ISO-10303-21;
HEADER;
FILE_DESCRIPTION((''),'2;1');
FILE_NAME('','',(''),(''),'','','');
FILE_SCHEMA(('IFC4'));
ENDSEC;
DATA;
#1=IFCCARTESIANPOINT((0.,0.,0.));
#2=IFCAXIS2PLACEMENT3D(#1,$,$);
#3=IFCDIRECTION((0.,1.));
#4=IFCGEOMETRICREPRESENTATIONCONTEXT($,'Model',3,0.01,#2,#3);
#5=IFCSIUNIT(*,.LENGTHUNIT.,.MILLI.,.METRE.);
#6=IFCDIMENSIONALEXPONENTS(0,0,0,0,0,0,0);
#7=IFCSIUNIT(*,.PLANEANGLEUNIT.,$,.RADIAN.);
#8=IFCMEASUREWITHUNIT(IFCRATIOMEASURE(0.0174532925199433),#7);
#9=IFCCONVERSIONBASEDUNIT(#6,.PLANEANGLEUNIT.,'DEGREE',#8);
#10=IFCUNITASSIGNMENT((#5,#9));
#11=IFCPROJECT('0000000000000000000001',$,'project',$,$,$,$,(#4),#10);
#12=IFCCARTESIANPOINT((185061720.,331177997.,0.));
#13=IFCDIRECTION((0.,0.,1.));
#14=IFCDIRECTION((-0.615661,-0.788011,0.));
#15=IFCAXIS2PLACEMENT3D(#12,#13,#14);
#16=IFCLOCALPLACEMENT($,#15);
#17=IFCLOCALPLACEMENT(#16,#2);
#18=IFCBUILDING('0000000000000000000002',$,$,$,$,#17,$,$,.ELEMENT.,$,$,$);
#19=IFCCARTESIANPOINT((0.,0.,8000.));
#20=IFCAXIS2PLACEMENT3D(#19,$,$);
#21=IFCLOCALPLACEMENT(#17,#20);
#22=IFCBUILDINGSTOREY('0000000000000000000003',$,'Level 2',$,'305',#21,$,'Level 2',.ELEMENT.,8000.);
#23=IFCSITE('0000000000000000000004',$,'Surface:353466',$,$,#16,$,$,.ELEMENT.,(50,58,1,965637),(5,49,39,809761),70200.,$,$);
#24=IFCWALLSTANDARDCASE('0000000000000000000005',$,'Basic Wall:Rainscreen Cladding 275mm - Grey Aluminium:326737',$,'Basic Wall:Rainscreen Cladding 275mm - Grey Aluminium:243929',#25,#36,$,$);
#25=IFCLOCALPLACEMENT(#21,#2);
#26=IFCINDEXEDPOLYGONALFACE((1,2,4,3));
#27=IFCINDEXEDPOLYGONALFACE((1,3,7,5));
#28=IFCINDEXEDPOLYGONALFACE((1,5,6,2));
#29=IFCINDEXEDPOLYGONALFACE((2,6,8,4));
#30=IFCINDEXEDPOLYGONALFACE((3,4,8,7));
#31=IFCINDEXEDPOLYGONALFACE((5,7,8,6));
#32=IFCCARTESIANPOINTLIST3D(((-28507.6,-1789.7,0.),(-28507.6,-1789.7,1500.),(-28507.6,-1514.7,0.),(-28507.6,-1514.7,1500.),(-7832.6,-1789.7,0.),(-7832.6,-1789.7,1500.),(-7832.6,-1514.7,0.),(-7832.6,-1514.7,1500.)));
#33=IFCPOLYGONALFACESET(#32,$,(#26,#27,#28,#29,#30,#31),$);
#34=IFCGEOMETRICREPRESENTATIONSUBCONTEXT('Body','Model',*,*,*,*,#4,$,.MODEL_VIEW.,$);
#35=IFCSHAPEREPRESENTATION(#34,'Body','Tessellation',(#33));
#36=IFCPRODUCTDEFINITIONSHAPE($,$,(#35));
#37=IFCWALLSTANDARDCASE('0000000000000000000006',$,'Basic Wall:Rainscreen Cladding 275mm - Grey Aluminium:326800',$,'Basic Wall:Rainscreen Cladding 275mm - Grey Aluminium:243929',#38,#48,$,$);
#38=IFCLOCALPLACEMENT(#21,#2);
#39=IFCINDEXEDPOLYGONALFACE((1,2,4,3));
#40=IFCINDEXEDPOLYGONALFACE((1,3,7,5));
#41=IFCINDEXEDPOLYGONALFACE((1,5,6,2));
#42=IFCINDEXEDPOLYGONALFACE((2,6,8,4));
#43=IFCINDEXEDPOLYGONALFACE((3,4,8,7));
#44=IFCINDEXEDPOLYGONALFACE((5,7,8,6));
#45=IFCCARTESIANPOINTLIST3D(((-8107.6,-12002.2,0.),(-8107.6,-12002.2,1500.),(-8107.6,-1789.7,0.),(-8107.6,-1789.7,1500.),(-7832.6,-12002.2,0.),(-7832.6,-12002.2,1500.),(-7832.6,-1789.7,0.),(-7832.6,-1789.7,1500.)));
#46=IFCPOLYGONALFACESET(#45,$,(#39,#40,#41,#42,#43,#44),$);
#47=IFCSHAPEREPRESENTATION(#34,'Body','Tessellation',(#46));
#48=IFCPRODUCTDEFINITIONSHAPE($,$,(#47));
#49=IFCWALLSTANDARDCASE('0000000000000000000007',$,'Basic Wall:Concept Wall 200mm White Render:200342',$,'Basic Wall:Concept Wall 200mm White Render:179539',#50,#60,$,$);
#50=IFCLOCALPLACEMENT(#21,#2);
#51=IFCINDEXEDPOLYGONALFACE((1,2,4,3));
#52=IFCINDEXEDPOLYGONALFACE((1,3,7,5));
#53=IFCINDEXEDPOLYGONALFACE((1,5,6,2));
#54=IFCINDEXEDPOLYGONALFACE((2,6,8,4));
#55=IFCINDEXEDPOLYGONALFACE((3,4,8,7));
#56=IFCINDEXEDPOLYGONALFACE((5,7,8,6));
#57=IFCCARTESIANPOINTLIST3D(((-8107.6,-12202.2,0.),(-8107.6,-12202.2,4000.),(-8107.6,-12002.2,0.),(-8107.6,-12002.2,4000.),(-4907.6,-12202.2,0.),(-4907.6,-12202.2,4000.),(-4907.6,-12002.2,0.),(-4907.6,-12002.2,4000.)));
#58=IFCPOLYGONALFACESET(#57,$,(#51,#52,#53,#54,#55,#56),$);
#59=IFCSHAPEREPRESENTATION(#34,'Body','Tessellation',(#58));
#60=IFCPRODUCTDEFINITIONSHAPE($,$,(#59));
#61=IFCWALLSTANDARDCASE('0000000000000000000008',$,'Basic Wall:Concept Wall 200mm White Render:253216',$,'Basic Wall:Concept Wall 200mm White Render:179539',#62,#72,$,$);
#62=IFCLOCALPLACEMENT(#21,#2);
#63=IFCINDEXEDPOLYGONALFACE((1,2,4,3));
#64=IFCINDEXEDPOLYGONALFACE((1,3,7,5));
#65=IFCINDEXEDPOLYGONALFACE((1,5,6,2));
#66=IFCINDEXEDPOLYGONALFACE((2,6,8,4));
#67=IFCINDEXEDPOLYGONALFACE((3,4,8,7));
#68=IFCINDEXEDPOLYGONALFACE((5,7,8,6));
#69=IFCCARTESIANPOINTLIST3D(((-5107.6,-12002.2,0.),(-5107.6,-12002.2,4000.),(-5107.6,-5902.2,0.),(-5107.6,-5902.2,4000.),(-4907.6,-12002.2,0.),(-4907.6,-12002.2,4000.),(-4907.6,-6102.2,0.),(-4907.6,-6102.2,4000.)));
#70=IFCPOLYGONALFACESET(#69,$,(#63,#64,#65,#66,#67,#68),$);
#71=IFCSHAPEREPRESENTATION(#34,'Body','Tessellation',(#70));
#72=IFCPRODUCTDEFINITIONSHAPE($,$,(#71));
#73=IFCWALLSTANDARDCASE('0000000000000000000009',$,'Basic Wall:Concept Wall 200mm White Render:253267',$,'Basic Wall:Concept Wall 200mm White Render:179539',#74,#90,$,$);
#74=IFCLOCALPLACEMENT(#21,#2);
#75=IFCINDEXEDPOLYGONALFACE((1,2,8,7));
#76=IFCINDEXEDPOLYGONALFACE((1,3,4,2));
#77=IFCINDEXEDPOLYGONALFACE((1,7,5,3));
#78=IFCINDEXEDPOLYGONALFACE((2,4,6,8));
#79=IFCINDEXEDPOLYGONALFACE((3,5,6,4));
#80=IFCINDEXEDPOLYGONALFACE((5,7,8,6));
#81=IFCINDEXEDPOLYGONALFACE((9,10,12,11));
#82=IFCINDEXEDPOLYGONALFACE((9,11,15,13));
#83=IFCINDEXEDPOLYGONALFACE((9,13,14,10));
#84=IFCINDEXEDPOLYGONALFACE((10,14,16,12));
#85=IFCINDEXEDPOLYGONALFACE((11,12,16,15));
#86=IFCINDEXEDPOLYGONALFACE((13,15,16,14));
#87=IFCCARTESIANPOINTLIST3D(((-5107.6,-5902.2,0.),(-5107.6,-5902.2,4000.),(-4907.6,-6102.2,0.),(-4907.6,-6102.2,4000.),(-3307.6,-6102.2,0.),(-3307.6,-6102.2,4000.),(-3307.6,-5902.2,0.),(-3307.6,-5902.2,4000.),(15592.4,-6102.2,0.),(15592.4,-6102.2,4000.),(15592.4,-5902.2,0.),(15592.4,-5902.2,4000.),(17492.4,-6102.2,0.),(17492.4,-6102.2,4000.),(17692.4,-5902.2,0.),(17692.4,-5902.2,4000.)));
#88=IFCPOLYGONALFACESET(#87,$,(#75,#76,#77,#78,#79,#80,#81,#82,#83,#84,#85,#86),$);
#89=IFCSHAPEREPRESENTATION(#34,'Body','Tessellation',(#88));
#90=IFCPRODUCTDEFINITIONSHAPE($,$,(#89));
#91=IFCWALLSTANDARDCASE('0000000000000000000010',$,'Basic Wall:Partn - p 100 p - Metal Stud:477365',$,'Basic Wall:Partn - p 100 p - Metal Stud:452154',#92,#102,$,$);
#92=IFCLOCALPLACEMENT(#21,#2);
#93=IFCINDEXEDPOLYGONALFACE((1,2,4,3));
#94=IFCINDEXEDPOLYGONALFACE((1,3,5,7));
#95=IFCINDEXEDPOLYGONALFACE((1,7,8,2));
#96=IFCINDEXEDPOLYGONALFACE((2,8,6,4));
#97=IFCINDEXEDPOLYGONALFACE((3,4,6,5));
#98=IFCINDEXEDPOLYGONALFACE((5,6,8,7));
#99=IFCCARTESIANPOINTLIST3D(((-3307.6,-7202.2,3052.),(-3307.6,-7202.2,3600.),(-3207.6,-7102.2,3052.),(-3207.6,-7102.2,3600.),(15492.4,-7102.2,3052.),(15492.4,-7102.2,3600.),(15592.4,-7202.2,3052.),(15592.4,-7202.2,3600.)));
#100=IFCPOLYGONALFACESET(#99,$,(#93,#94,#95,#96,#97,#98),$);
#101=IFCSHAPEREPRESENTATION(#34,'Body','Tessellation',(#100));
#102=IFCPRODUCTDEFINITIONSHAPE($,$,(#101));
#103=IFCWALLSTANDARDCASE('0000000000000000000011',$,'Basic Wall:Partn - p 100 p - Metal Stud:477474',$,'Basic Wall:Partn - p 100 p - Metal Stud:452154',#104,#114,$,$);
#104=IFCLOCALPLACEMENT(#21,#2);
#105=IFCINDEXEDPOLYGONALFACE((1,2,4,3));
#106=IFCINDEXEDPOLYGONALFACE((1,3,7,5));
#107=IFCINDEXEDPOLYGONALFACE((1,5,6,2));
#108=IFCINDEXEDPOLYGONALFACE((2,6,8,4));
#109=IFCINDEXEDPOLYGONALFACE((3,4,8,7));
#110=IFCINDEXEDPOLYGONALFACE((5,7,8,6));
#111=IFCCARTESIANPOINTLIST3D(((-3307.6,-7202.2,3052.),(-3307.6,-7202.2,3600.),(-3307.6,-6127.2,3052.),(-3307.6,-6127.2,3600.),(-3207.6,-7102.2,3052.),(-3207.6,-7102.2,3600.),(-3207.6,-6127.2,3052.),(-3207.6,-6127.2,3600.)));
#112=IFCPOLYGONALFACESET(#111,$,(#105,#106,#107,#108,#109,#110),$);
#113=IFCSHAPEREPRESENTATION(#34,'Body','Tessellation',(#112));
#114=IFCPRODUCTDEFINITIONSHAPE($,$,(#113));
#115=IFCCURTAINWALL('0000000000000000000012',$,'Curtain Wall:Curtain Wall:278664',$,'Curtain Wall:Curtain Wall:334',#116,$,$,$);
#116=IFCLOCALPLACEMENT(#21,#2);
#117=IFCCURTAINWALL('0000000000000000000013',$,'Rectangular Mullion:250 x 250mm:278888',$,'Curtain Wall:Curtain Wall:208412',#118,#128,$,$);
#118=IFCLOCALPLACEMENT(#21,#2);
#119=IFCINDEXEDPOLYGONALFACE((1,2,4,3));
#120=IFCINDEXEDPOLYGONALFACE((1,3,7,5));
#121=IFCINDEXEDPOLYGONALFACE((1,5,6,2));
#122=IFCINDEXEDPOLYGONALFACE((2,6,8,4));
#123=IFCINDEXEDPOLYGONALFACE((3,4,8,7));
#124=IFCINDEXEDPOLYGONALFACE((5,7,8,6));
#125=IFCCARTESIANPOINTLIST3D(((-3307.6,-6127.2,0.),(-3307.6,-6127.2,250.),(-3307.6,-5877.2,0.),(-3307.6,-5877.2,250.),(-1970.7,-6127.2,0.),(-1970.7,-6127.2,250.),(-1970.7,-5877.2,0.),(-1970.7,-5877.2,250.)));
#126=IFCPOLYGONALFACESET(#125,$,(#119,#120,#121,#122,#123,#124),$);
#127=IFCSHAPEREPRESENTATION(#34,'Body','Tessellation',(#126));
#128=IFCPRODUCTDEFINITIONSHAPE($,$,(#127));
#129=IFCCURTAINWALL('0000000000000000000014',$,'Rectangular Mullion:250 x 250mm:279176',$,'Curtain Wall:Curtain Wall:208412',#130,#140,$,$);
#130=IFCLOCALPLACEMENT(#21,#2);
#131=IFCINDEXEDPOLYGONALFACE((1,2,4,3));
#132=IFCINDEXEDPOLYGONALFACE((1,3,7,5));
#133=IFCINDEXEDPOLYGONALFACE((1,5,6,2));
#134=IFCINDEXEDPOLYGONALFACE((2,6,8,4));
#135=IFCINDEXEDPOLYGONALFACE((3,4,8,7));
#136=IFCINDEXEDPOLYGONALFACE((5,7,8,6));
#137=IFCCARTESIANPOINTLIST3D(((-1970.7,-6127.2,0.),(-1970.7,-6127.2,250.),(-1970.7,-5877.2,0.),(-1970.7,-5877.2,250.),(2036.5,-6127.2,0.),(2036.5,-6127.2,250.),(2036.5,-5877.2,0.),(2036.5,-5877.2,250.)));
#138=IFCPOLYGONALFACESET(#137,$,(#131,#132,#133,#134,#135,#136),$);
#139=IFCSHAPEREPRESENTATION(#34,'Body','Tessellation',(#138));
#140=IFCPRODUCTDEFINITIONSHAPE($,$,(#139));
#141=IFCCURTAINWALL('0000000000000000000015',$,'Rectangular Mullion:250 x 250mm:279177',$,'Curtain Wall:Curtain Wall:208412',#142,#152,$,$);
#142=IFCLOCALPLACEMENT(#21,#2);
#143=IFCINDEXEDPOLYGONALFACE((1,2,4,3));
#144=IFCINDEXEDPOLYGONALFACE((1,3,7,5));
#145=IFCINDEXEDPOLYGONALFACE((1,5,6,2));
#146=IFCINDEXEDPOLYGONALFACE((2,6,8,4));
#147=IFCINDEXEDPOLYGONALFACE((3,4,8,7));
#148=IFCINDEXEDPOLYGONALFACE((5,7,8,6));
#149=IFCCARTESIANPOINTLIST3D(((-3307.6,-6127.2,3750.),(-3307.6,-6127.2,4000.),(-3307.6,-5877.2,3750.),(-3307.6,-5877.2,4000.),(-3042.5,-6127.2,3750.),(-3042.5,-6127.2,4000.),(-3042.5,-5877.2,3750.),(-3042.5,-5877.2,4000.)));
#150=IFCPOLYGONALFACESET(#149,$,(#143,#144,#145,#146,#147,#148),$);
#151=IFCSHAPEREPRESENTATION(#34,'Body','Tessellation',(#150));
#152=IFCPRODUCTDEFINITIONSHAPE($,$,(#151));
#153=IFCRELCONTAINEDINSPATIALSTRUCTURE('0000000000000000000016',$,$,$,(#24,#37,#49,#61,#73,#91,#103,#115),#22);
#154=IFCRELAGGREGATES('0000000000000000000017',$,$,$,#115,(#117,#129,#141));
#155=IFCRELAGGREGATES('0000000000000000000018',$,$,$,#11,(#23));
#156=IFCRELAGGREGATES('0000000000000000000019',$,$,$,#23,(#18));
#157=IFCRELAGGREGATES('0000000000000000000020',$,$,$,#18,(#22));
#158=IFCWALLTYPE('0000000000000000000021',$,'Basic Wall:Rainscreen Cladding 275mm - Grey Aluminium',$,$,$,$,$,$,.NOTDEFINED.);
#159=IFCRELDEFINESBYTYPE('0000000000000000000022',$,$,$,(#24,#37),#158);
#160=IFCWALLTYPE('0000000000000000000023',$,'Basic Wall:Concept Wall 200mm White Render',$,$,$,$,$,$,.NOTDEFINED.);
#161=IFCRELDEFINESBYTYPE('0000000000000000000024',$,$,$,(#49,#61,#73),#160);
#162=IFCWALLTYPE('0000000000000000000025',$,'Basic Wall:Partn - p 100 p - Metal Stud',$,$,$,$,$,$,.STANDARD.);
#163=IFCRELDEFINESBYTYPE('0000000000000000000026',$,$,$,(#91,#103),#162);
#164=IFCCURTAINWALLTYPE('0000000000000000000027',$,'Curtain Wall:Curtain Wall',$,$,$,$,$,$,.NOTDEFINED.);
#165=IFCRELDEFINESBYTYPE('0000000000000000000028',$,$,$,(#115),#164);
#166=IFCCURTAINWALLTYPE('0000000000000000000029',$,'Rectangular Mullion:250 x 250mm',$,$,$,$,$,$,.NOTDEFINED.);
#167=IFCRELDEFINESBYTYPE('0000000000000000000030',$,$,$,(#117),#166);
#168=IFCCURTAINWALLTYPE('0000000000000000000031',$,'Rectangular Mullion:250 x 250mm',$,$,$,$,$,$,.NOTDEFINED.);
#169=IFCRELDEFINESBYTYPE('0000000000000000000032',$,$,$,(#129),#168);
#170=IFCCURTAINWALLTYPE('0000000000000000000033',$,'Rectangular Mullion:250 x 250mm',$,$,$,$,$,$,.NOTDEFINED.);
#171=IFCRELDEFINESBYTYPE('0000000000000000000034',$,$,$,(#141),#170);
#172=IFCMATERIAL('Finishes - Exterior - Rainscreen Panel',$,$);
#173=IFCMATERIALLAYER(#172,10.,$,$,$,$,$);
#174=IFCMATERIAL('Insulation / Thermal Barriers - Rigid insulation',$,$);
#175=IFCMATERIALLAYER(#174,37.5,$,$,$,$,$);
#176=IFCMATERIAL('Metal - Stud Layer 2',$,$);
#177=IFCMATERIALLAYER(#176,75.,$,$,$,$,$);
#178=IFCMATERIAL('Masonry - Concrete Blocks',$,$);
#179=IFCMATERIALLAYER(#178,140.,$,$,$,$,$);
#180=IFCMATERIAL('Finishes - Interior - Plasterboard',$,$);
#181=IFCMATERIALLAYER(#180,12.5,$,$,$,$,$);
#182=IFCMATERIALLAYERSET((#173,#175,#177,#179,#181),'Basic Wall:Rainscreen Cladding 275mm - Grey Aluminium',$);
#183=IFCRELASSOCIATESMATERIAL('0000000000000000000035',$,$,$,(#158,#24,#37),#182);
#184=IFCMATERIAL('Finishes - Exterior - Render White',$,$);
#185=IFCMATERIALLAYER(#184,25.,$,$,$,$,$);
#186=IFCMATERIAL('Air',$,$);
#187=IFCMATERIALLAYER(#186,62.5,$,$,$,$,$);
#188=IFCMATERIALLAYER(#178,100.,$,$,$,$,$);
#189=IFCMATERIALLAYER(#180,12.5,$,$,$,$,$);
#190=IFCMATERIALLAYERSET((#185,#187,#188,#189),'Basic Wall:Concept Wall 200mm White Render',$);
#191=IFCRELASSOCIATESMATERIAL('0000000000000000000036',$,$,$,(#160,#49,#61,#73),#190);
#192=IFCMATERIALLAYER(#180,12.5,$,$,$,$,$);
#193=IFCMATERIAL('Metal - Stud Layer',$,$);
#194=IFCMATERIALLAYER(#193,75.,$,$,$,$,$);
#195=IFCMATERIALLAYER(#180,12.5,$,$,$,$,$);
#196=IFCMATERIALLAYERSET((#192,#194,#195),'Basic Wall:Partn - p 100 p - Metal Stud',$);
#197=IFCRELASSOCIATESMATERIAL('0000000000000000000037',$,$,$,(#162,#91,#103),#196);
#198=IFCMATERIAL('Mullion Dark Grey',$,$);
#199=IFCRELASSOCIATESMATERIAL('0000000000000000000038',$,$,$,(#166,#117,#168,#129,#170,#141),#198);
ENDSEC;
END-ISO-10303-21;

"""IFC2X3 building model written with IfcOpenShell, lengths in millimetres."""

from ifc_helpers import new_model, entity, si_unit, converted_unit, direction, frame, frame_2d, origin, origin_2d_with_axis, place, context, subcontext, project, spatial, polyline, rectangle, outline, extrude, clip, halfspace, bounded_halfspace, source, transform, mapped, material, layer, layer_set, layer_usage, type_object, type_shapes, element, aggregate, save


model = new_model("IFC2X3")

# Units and contexts
model_context = context("Model", 3, precision=0.01, world=origin(), true_north=direction((0.0, 1.0)))
body_context = subcontext(model_context, "Body", "Model", "MODEL_VIEW")
ifc_project = project(units=[si_unit("LENGTHUNIT", "METRE", prefix="MILLI"), converted_unit("PLANEANGLEUNIT", "DEGREE", entity("IfcRatioMeasure", 0.0174532925199433), si_unit("PLANEANGLEUNIT", "RADIAN"), dimensions=[0, 0, 0, 0, 0, 0, 0])], contexts=[model_context])

# Site, building, storey
site_placement = place(None, frame((185061720.0, 331177997.0, 0.0), z_axis=(0.0, 0.0, 1.0), x_axis=(-0.615661, -0.788011, 0.0)))
site = spatial("IfcSite", under=ifc_project, at=site_placement, Name="Surface:353466", CompositionType="ELEMENT", RefLatitude=(50, 58, 1, 965637), RefLongitude=(5, 49, 39, 809761), RefElevation=70200.0)
building_placement = place(site_placement, origin())
building = spatial("IfcBuilding", under=site, at=building_placement, CompositionType="ELEMENT")
storey_placement = place(building_placement, frame((0.0, 0.0, 8000.0)))
storey = spatial("IfcBuildingStorey", under=building, at=storey_placement, Name="Level 2", ObjectType="305", LongName="Level 2", CompositionType="ELEMENT", Elevation=8000.0)

# Walls
ifc_material_1 = material(Name="Finishes - Exterior - Rainscreen Panel")
ifc_layer_1 = layer(ifc_material_1, 10.0)
ifc_material_2 = material(Name="Insulation / Thermal Barriers - Rigid insulation")
ifc_layer_2 = layer(ifc_material_2, 37.5)
ifc_material_3 = material(Name="Metal - Stud Layer 2")
ifc_layer_3 = layer(ifc_material_3, 75.0)
ifc_material_4 = material(Name="Masonry - Concrete Blocks")
ifc_layer_4 = layer(ifc_material_4, 140.0)
ifc_material_5 = material(Name="Finishes - Interior - Plasterboard")
ifc_layer_5 = layer(ifc_material_5, 12.5)
ifc_layer_set_1 = layer_set([ifc_layer_1, ifc_layer_2, ifc_layer_3, ifc_layer_4, ifc_layer_5], Name="Basic Wall:Rainscreen Cladding 275mm - Grey Aluminium")
ifc_layer_usage_1 = layer_usage(ifc_layer_set_1, "AXIS2", "NEGATIVE", 137.5)
wall_type_1 = type_object("IfcWallType", Name="Basic Wall:Rainscreen Cladding 275mm - Grey Aluminium", PredefinedType="NOTDEFINED", material=ifc_layer_set_1)
wall_1_placement = place(storey_placement, frame((-28507.6, -1652.2, 0.0)))
element("IfcWallStandardCase", 1, at=wall_1_placement, inside=storey, type_object=wall_type_1, material=ifc_layer_usage_1, Name="Basic Wall:Rainscreen Cladding 275mm - Grey Aluminium:326737", ObjectType="Basic Wall:Rainscreen Cladding 275mm - Grey Aluminium:243929", context=body_context, shape_type="Clipping", body=[
    clip(extrude(rectangle(XDim=20675.0, YDim=275.0, at=frame_2d((10337.5, 0.0), x_axis=(-1.0, 0.0))), origin(), (0.0, 0.0, 1.0), 1500.0), halfspace(frame((0.0, 0.0, -8000.0)), True)),
])
ifc_layer_usage_2 = layer_usage(ifc_layer_set_1, "AXIS2", "NEGATIVE", 137.5)
wall_2_placement = place(storey_placement, frame((-7970.1, -1789.7, 0.0), z_axis=(0.0, 0.0, 1.0), x_axis=(0.0, -1.0, 0.0)))
element("IfcWallStandardCase", 2, at=wall_2_placement, inside=storey, type_object=wall_type_1, material=ifc_layer_usage_2, Name="Basic Wall:Rainscreen Cladding 275mm - Grey Aluminium:326800", ObjectType="Basic Wall:Rainscreen Cladding 275mm - Grey Aluminium:243929", context=body_context, shape_type="Clipping", body=[
    clip(extrude(rectangle(XDim=10212.5, YDim=275.0, at=frame_2d((5106.2, 0.0), x_axis=(-1.0, 0.0))), origin(), (0.0, 0.0, 1.0), 1500.0), halfspace(frame((0.0, 0.0, -8000.0)), True)),
])
ifc_material_6 = material(Name="Finishes - Exterior - Render White")
ifc_layer_6 = layer(ifc_material_6, 25.0)
ifc_material_7 = material(Name="Air")
ifc_layer_7 = layer(ifc_material_7, 62.5)
ifc_layer_8 = layer(ifc_material_4, 100.0)
ifc_layer_9 = layer(ifc_material_5, 12.5)
ifc_layer_set_2 = layer_set([ifc_layer_6, ifc_layer_7, ifc_layer_8, ifc_layer_9], Name="Basic Wall:Concept Wall 200mm White Render")
ifc_layer_usage_3 = layer_usage(ifc_layer_set_2, "AXIS2", "NEGATIVE", 100.0)
wall_type_2 = type_object("IfcWallType", Name="Basic Wall:Concept Wall 200mm White Render", PredefinedType="NOTDEFINED", material=ifc_layer_set_2)
wall_3_placement = place(storey_placement, frame((-8107.6, -12102.2, 0.0)))
element("IfcWallStandardCase", 3, at=wall_3_placement, inside=storey, type_object=wall_type_2, material=ifc_layer_usage_3, Name="Basic Wall:Concept Wall 200mm White Render:200342", ObjectType="Basic Wall:Concept Wall 200mm White Render:179539", context=body_context, shape_type="Clipping", body=[
    clip(extrude(rectangle(XDim=3200.0, YDim=200.0, at=frame_2d((1600.0, 0.0), x_axis=(-1.0, 0.0))), origin(), (0.0, 0.0, 1.0), 4000.0), halfspace(frame((0.0, 0.0, -8000.0)), True)),
])
ifc_layer_usage_4 = layer_usage(ifc_layer_set_2, "AXIS2", "NEGATIVE", 100.0)
wall_4_placement = place(storey_placement, frame((-5007.6, -12002.2, 0.0), z_axis=(0.0, 0.0, 1.0), x_axis=(0.0, 1.0, 0.0)))
element("IfcWallStandardCase", 4, at=wall_4_placement, inside=storey, type_object=wall_type_2, material=ifc_layer_usage_4, Name="Basic Wall:Concept Wall 200mm White Render:253216", ObjectType="Basic Wall:Concept Wall 200mm White Render:179539", context=body_context, shape_type="Clipping", body=[
    clip(extrude(outline(polyline([(5900.0, -100.0), (6100.0, 100.0), (0.0, 100.0), (0.0, -100.0), (5900.0, -100.0)])), origin(), (0.0, 0.0, 1.0), 4000.0), halfspace(frame((0.0, 0.0, -8000.0)), True)),
])

# Wall, opening
ifc_layer_usage_5 = layer_usage(ifc_layer_set_2, "AXIS2", "NEGATIVE", 100.0)
wall_5_placement = place(storey_placement, frame((-5107.6, -6002.2, 0.0)))
wall_5 = element("IfcWallStandardCase", 5, at=wall_5_placement, inside=storey, type_object=wall_type_2, material=ifc_layer_usage_5, Name="Basic Wall:Concept Wall 200mm White Render:253267", ObjectType="Basic Wall:Concept Wall 200mm White Render:179539", context=body_context, shape_type="Clipping", body=[
    clip(extrude(outline(polyline([(200.0, -100.0), (22600.0, -100.0), (22800.0, 100.0), (0.0, 100.0), (200.0, -100.0)])), origin(), (0.0, 0.0, 1.0), 4000.0), halfspace(frame((0.0, 0.0, -8000.0)), True)),
])
opening_1_placement = place(wall_5_placement, frame((1800.0, -252.4, 0.0)))
element("IfcOpeningElement", 6, at=opening_1_placement, cuts=wall_5, ObjectType="Opening", context=body_context, shape_type="SweptSolid", body=[
    extrude(rectangle(XDim=4000.0, YDim=18900.0, at=frame_2d((0.0, 0.0), x_axis=(1.0, 0.0))), frame((9450.0, 0.0, 2000.0), z_axis=(0.0, 1.0, 0.0), x_axis=(0.0, 0.0, 1.0)), (0.0, 0.0, 1.0), 504.8),
])

# Walls
ifc_layer_10 = layer(ifc_material_5, 12.5)
ifc_material_8 = material(Name="Metal - Stud Layer")
ifc_layer_11 = layer(ifc_material_8, 75.0)
ifc_layer_12 = layer(ifc_material_5, 12.5)
ifc_layer_set_3 = layer_set([ifc_layer_10, ifc_layer_11, ifc_layer_12], Name="Basic Wall:Partn - p 100 p - Metal Stud")
ifc_layer_usage_6 = layer_usage(ifc_layer_set_3, "AXIS2", "NEGATIVE", 50.0)
wall_type_3 = type_object("IfcWallType", Name="Basic Wall:Partn - p 100 p - Metal Stud", PredefinedType="STANDARD", material=ifc_layer_set_3)
wall_6_placement = place(storey_placement, frame((-3307.6, -7152.2, 3052.0)))
element("IfcWallStandardCase", 7, at=wall_6_placement, inside=storey, type_object=wall_type_3, material=ifc_layer_usage_6, Name="Basic Wall:Partn - p 100 p - Metal Stud:477365", ObjectType="Basic Wall:Partn - p 100 p - Metal Stud:452154", context=body_context, shape_type="Clipping", body=[
    clip(extrude(outline(polyline([(18900.0, -50.0), (18800.0, 50.0), (100.0, 50.0), (0.0, -50.0), (18900.0, -50.0)])), origin(), (0.0, 0.0, 1.0), 548.0), bounded_halfspace(frame((0.0, -50.0, 548.0), z_axis=(0.0, 0.0, -1.0), x_axis=(1.0, 0.0, 0.0)), True, frame((0.0, -50.0, 548.0)), polyline([(0.0, 0.0), (18900.0, 0.0), (18800.0, 100.0), (100.0, 100.0), (0.0, 0.0)]))),
])
ifc_layer_usage_7 = layer_usage(ifc_layer_set_3, "AXIS2", "NEGATIVE", 50.0)
wall_7_placement = place(storey_placement, frame((-3257.6, -6127.2, 3052.0), z_axis=(0.0, 0.0, 1.0), x_axis=(0.0, -1.0, 0.0)))
element("IfcWallStandardCase", 8, at=wall_7_placement, inside=storey, type_object=wall_type_3, material=ifc_layer_usage_7, Name="Basic Wall:Partn - p 100 p - Metal Stud:477474", ObjectType="Basic Wall:Partn - p 100 p - Metal Stud:452154", context=body_context, shape_type="SweptSolid", body=[
    extrude(outline(polyline([(1075.0, -50.0), (975.0, 50.0), (0.0, 50.0), (0.0, -50.0), (1075.0, -50.0)])), origin(), (0.0, 0.0, 1.0), 548.0),
])

# Curtain walls
curtain_wall_type_1 = type_object("IfcCurtainWallType", Name="Curtain Wall:Curtain Wall", PredefinedType="NOTDEFINED")
curtain_wall_1_placement = place(storey_placement, frame((0.0, 0.0, -8000.0)))
curtain_wall_1 = element("IfcCurtainWall", 9, at=curtain_wall_1_placement, inside=storey, type_object=curtain_wall_type_1, Name="Curtain Wall:Curtain Wall:278664", ObjectType="Curtain Wall:Curtain Wall:334")
ifc_material_9 = material(Name="Mullion Dark Grey")
curtain_wall_type_2 = type_object("IfcCurtainWallType", Name="Rectangular Mullion:250 x 250mm", PredefinedType="NOTDEFINED", material=ifc_material_9)
shared_shape_1 = source(origin(), body_context, "Body", "SweptSolid", [
    extrude(rectangle(XDim=250.0, YDim=250.0, at=origin_2d_with_axis()), frame((-125.0, 0.0, -1336.8), z_axis=(0.0, 0.0, 1.0), x_axis=(-1.0, 0.0, 0.0)), (0.0, 0.0, 1.0), 1336.8),
])
type_shapes(curtain_wall_type_2, [shared_shape_1])
curtain_wall_2_placement = place(storey_placement, frame((-3307.6, -6002.2, 0.0), z_axis=(-1.0, 0.0, 0.0), x_axis=(0.0, 0.0, -1.0)))
curtain_wall_2 = element("IfcCurtainWall", 10, at=curtain_wall_2_placement, type_object=curtain_wall_type_2, material=ifc_material_9, Name="Rectangular Mullion:250 x 250mm:278888", ObjectType="Curtain Wall:Curtain Wall:208412", context=body_context, shape_type="MappedRepresentation", body=[
    mapped(shared_shape_1, transform((0.0, 0.0, 0.0), scale=1.0)),
])
curtain_wall_type_3 = type_object("IfcCurtainWallType", Name="Rectangular Mullion:250 x 250mm", PredefinedType="NOTDEFINED", material=ifc_material_9)
shared_shape_2 = source(origin(), body_context, "Body", "SweptSolid", [
    extrude(rectangle(XDim=250.0, YDim=250.0, at=origin_2d_with_axis()), frame((-125.0, 0.0, -4007.2), z_axis=(0.0, 0.0, 1.0), x_axis=(-1.0, 0.0, 0.0)), (0.0, 0.0, 1.0), 4007.2),
])
type_shapes(curtain_wall_type_3, [shared_shape_2])
curtain_wall_3_placement = place(storey_placement, frame((-1970.7, -6002.2, 0.0), z_axis=(-1.0, 0.0, 0.0), x_axis=(0.0, 0.0, -1.0)))
curtain_wall_3 = element("IfcCurtainWall", 11, at=curtain_wall_3_placement, type_object=curtain_wall_type_3, material=ifc_material_9, Name="Rectangular Mullion:250 x 250mm:279176", ObjectType="Curtain Wall:Curtain Wall:208412", context=body_context, shape_type="MappedRepresentation", body=[
    mapped(shared_shape_2, transform((0.0, 0.0, 0.0), scale=1.0)),
])
curtain_wall_type_4 = type_object("IfcCurtainWallType", Name="Rectangular Mullion:250 x 250mm", PredefinedType="NOTDEFINED", material=ifc_material_9)
shared_shape_3 = source(origin(), body_context, "Body", "SweptSolid", [
    extrude(rectangle(XDim=250.0, YDim=250.0, at=origin_2d_with_axis()), frame((-125.0, 0.0, -265.0), z_axis=(0.0, 0.0, 1.0), x_axis=(-1.0, 0.0, 0.0)), (0.0, 0.0, 1.0), 265.0),
])
type_shapes(curtain_wall_type_4, [shared_shape_3])
curtain_wall_4_placement = place(storey_placement, frame((-3042.5, -6002.2, 4000.0), z_axis=(1.0, 0.0, 0.0), x_axis=(0.0, 0.0, 1.0)))
curtain_wall_4 = element("IfcCurtainWall", 12, at=curtain_wall_4_placement, type_object=curtain_wall_type_4, material=ifc_material_9, Name="Rectangular Mullion:250 x 250mm:279177", ObjectType="Curtain Wall:Curtain Wall:208412", context=body_context, shape_type="MappedRepresentation", body=[
    mapped(shared_shape_3, transform((0.0, 0.0, 0.0), scale=1.0)),
])
aggregate(curtain_wall_1, [curtain_wall_2, curtain_wall_3, curtain_wall_4])

save(model, "model.ifc")
